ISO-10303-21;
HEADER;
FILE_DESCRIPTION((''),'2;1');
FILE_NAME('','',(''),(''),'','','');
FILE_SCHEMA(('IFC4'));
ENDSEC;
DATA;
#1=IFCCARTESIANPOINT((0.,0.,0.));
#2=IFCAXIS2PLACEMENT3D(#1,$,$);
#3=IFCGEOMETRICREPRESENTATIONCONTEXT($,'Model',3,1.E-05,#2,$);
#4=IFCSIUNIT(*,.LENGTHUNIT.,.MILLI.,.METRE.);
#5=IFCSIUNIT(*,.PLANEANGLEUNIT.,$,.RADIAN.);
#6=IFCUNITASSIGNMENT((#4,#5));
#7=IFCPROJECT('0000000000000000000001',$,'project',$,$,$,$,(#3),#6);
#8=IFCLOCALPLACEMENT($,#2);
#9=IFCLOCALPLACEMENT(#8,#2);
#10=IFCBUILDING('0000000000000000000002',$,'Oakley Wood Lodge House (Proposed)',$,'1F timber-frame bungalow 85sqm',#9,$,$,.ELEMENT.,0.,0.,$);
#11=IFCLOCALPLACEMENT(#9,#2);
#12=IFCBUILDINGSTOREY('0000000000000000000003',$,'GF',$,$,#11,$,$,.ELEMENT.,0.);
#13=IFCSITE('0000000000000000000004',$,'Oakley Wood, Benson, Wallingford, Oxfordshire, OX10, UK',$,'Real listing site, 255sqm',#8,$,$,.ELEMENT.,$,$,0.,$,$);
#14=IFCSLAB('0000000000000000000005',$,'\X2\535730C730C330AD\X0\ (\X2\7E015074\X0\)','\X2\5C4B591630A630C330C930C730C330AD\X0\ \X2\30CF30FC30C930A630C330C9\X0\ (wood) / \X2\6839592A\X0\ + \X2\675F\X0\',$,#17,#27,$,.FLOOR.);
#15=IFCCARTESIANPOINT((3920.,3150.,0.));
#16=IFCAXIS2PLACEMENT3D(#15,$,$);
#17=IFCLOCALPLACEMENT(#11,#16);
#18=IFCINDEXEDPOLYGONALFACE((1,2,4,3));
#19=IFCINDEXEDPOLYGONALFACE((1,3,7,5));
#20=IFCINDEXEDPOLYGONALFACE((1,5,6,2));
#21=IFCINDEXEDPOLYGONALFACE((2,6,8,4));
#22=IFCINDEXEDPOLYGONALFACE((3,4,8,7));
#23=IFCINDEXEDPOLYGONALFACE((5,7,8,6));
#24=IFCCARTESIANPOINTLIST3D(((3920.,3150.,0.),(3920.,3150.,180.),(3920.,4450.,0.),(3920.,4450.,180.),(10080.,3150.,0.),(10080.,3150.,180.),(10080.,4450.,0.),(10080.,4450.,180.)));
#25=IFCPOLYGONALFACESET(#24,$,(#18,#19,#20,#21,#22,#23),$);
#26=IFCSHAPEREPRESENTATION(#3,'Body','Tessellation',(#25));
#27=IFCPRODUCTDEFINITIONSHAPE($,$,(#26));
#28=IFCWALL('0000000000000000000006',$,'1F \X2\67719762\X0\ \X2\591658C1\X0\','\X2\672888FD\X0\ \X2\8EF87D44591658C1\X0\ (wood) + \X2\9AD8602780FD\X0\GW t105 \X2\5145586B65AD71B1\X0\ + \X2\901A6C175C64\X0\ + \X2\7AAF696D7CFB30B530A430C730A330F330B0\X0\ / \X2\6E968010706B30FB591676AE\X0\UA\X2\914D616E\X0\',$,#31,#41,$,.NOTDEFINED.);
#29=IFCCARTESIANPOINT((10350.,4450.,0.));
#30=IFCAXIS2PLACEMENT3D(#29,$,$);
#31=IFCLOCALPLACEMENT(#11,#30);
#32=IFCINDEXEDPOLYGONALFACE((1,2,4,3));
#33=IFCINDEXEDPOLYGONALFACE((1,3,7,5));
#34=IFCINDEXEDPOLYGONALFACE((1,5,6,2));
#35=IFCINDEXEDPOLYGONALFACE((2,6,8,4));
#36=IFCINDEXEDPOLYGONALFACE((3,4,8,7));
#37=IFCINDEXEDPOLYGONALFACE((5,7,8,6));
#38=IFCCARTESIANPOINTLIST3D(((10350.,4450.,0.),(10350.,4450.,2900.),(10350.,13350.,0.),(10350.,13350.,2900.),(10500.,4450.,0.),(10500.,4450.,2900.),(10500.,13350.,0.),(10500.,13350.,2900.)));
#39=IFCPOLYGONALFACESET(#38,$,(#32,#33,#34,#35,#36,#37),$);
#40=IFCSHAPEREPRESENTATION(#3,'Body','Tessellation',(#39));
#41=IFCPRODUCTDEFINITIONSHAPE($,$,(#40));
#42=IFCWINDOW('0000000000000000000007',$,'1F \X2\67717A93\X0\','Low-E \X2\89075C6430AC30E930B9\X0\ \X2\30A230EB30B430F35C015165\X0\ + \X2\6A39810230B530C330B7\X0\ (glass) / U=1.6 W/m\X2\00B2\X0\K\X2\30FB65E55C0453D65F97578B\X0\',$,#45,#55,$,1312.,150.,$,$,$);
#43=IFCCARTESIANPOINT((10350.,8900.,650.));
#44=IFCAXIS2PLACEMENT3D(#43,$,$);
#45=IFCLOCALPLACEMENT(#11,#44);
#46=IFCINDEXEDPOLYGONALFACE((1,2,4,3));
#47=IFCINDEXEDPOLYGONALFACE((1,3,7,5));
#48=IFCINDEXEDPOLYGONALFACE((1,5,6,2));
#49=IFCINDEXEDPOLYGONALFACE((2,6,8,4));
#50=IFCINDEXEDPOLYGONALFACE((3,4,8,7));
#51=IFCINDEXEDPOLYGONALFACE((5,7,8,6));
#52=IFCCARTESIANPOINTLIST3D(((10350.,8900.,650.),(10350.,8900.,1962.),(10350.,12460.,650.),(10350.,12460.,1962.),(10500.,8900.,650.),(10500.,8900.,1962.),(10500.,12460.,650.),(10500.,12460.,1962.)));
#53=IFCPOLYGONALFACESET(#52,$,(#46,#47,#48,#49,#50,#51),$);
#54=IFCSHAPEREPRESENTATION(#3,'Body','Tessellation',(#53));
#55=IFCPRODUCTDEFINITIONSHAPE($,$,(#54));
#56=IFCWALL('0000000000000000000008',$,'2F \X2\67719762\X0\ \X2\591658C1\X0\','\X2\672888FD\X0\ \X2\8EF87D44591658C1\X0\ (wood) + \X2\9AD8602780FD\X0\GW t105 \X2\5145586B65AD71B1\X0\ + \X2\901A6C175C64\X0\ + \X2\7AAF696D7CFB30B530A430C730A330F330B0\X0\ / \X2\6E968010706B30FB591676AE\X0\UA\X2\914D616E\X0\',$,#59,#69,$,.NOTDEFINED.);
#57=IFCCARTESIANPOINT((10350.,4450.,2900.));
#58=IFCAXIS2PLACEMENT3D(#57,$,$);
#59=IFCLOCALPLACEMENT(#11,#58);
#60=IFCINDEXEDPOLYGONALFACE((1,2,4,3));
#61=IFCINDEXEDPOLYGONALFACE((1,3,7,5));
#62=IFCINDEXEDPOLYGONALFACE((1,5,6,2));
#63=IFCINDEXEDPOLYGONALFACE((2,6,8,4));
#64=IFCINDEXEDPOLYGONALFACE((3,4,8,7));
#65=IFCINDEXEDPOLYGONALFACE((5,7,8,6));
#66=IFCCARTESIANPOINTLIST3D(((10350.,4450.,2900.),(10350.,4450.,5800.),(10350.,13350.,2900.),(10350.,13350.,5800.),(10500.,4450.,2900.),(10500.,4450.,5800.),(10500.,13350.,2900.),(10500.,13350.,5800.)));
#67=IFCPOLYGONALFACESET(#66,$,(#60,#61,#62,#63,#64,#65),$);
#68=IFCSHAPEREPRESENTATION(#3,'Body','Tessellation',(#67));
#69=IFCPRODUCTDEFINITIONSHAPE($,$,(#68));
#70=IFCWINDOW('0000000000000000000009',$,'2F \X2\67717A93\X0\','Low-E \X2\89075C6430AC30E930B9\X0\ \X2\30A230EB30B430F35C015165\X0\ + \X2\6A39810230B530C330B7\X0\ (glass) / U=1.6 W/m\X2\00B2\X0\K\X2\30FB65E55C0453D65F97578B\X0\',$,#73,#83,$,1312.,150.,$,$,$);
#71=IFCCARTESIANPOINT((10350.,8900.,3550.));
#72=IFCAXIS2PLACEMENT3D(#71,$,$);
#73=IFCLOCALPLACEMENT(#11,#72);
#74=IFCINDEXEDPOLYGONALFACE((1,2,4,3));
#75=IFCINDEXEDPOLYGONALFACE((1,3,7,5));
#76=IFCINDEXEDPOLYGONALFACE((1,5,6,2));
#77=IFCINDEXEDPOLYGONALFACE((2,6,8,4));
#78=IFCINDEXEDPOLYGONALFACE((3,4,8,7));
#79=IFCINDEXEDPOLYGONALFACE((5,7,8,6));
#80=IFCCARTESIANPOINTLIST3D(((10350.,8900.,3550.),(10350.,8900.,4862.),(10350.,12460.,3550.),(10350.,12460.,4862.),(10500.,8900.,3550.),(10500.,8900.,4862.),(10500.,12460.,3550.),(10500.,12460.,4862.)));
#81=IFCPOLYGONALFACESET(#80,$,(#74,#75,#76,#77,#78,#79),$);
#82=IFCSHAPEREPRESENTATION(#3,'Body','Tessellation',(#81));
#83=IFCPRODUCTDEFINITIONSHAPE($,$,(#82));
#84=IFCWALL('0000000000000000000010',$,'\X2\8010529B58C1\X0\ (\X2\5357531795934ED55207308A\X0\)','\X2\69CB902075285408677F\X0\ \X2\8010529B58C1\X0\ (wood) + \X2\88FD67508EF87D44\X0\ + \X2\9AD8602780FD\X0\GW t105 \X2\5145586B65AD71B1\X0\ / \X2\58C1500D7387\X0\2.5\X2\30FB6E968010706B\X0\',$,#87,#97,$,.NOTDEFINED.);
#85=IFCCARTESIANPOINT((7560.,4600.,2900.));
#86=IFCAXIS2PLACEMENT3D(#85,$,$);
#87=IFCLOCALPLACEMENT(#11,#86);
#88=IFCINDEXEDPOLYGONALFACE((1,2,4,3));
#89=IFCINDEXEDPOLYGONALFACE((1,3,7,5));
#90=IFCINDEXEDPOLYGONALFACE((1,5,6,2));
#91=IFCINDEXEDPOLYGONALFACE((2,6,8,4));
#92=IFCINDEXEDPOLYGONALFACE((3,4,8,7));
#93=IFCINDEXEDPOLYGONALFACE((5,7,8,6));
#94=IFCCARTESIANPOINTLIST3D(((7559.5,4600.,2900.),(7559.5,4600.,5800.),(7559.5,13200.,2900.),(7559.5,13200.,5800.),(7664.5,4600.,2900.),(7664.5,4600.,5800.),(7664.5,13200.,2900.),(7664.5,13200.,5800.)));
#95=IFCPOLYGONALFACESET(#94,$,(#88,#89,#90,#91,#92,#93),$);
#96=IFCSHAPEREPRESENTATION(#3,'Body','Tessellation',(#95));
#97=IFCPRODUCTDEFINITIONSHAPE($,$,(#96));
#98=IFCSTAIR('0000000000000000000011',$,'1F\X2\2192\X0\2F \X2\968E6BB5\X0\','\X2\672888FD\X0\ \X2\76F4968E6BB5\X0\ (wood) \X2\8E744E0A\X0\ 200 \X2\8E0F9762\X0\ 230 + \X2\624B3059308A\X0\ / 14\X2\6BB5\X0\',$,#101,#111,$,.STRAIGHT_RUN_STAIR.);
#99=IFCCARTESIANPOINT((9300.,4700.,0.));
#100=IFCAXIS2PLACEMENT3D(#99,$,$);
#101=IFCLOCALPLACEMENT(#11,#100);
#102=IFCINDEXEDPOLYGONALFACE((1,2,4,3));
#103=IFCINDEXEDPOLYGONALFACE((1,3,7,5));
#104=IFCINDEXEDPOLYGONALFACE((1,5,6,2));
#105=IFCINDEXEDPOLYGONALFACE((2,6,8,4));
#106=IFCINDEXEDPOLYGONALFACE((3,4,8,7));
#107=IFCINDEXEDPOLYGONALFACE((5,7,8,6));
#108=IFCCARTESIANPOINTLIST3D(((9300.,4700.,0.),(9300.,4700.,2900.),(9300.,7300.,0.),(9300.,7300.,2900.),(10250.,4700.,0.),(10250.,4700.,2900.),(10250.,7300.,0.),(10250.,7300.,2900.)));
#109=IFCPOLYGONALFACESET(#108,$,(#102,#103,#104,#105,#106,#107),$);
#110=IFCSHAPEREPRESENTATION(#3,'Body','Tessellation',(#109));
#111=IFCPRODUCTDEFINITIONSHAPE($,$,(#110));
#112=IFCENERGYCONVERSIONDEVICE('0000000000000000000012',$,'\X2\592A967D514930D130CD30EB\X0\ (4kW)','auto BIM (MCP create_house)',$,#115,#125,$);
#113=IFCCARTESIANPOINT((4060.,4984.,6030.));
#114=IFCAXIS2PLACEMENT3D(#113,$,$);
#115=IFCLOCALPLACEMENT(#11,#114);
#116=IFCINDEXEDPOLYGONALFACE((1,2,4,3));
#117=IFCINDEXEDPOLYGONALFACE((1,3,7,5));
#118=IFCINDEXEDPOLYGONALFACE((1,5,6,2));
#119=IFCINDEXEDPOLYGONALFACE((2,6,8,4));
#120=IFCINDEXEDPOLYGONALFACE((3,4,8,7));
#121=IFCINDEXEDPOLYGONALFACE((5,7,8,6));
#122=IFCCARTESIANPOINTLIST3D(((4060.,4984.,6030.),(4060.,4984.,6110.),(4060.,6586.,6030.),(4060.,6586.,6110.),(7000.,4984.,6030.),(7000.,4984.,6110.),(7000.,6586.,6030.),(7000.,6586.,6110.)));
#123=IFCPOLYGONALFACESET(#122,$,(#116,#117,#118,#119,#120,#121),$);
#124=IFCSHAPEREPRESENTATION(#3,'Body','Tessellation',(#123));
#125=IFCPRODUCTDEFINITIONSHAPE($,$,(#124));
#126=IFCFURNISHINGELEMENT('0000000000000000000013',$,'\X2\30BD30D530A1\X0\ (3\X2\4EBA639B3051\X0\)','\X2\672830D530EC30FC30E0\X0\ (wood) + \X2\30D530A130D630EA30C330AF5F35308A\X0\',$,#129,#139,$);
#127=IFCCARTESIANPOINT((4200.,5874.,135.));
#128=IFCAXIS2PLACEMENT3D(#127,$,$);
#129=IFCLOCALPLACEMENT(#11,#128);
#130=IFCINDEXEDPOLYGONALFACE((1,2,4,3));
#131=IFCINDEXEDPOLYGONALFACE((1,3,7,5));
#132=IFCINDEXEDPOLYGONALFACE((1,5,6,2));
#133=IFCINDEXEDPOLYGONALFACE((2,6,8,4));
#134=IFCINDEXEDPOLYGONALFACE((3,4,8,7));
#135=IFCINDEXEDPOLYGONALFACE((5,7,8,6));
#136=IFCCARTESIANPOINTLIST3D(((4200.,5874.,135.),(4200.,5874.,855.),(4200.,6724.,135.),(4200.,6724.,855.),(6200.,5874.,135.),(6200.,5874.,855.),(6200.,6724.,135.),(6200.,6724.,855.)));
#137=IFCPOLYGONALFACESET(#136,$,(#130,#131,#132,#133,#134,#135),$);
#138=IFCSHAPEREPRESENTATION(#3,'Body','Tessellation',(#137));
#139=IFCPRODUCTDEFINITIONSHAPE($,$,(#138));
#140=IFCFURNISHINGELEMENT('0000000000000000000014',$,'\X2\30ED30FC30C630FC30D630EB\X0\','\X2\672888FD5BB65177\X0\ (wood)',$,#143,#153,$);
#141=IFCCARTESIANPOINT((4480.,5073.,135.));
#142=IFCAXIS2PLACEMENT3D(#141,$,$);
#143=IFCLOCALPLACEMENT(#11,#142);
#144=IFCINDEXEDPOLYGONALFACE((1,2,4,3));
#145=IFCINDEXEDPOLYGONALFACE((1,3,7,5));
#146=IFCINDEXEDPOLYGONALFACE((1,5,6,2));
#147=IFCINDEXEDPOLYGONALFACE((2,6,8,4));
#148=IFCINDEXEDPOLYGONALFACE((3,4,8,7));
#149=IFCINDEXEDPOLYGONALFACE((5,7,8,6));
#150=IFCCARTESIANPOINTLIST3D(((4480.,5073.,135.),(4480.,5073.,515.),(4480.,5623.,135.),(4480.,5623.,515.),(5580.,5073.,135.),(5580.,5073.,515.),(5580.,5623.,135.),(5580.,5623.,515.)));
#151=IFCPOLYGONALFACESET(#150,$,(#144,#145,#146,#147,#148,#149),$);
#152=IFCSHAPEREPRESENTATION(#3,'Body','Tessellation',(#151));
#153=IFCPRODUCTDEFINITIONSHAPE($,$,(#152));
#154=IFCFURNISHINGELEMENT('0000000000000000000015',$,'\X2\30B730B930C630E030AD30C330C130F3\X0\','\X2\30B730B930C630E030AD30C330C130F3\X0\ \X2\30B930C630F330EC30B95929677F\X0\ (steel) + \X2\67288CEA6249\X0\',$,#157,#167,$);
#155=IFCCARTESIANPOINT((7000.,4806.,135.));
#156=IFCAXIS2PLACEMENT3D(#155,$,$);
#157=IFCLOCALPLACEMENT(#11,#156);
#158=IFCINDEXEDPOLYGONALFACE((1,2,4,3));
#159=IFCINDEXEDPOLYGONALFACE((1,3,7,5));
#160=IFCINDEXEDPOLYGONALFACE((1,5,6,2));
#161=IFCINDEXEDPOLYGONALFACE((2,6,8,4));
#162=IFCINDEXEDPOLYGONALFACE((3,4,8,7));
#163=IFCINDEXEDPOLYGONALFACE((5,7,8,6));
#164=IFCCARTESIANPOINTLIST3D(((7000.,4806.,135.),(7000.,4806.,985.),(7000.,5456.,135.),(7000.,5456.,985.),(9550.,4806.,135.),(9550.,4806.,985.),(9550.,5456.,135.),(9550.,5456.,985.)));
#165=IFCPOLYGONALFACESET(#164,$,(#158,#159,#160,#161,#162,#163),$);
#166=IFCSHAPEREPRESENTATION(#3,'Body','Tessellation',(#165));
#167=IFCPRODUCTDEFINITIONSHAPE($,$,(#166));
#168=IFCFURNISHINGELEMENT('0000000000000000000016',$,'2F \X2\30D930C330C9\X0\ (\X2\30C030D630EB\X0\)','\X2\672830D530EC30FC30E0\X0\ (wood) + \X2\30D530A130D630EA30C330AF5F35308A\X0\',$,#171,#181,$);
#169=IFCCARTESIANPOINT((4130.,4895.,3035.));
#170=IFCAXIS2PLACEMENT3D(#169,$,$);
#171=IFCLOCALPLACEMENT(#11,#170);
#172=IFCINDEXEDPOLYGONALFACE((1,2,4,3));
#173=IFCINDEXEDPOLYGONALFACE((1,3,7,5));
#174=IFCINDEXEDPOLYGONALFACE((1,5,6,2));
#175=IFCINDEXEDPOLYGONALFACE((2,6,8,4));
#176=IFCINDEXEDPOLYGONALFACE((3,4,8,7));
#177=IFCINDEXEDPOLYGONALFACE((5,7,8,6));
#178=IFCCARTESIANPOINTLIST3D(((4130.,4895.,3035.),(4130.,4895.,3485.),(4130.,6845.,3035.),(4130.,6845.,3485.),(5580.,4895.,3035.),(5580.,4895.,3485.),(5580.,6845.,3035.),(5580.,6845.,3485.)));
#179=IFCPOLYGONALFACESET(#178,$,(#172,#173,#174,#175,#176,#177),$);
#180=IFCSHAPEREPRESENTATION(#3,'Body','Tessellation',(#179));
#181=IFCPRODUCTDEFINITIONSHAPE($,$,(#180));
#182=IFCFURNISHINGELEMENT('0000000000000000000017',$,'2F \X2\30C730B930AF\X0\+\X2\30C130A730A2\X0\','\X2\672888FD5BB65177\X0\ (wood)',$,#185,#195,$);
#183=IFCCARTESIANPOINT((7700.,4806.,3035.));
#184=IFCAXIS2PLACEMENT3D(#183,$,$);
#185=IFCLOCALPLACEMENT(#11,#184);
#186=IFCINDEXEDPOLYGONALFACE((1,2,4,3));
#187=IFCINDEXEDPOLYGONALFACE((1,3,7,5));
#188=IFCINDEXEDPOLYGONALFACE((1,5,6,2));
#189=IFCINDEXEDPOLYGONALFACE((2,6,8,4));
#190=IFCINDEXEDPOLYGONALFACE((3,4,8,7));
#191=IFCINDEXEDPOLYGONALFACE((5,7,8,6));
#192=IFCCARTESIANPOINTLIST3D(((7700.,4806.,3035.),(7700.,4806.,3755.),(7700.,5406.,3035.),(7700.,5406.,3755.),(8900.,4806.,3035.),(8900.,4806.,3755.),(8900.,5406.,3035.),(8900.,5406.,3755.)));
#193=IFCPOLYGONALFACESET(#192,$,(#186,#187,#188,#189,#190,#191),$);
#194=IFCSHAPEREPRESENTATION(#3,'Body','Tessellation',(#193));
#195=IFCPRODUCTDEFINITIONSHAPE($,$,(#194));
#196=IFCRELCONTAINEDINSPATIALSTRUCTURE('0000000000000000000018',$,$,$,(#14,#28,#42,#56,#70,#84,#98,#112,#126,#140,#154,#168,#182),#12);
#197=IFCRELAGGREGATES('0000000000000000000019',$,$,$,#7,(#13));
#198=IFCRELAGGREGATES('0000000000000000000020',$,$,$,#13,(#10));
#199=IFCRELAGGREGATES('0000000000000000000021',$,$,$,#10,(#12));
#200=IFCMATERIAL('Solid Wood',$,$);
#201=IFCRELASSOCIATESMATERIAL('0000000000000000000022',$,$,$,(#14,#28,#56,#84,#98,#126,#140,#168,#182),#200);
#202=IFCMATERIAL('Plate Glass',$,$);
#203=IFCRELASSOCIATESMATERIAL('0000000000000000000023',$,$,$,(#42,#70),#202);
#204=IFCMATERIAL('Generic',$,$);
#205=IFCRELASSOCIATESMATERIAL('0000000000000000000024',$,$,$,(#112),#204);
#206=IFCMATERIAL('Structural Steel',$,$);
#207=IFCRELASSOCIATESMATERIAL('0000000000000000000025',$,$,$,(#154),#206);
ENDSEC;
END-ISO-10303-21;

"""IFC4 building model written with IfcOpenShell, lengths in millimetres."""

from ifc_helpers import new_model, si_unit, frame, frame_2d, origin, place, context, project, spatial, rectangle, extrude, material, element, fill, save


model = new_model("IFC4")

# Units and contexts
model_context = context("Model", 3, precision=1e-05, world=origin())
ifc_project = project(units=[si_unit("LENGTHUNIT", "METRE", prefix="MILLI"), si_unit("PLANEANGLEUNIT", "RADIAN")], contexts=[model_context])

# Site, building, storey
site_placement = place(None, origin())
site = spatial("IfcSite", under=ifc_project, at=site_placement, Name="Oakley Wood, Benson, Wallingford, Oxfordshire, OX10, UK", ObjectType="Real listing site, 255sqm", CompositionType="ELEMENT", RefElevation=0.0)
building_placement = place(site_placement, origin())
building = spatial("IfcBuilding", under=site, at=building_placement, Name="Oakley Wood Lodge House (Proposed)", ObjectType="1F timber-frame bungalow 85sqm", CompositionType="ELEMENT", ElevationOfRefHeight=0.0, ElevationOfTerrain=0.0)
storey_placement = place(building_placement, origin())
storey = spatial("IfcBuildingStorey", under=building, at=storey_placement, Name="GF", CompositionType="ELEMENT", Elevation=0.0)

# Slab
ifc_material_1 = material(Name="Solid Wood")
slab_placement = place(storey_placement, frame((3920.0, 3150.0, 0.0)))
element("IfcSlab", 1, at=slab_placement, inside=storey, material=ifc_material_1, Name="南デッキ (縁側)", Description="屋外ウッドデッキ ハードウッド (wood) / 根太 + 束", PredefinedType="FLOOR", context=model_context, shape_type="SweptSolid", body=[
    extrude(rectangle(XDim=6160.0, YDim=1300.0, at=frame_2d((3080.0, 650.0))), frame((3920.0, 3150.0, 0.0)), (0.0, 0.0, 1.0), 180.0),
])

# Wall, opening, window
wall_1_placement = place(storey_placement, frame((10350.0, 4450.0, 0.0)))
wall_1 = element("IfcWall", 2, at=wall_1_placement, inside=storey, material=ifc_material_1, Name="1F 東面 外壁", Description="木製 軸組外壁 (wood) + 高性能GW t105 充填断熱 + 通気層 + 窯業系サイディング / 準耐火・外皮UA配慮", PredefinedType="NOTDEFINED", context=model_context, shape_type="SweptSolid", body=[
    extrude(rectangle(XDim=150.0, YDim=8900.0, at=frame_2d((75.0, 4450.0))), frame((10350.0, 4450.0, 0.0)), (0.0, 0.0, 1.0), 2900.0),
])
opening_1_placement = place(storey_placement, frame((10350.0, 8900.0, 650.0)))
opening_1 = element("IfcOpeningElement", 3, at=opening_1_placement, cuts=wall_1, PredefinedType="NOTDEFINED", context=model_context, shape_type="SweptSolid", body=[
    extrude(rectangle(XDim=150.0, YDim=3560.0, at=frame_2d((75.0, 1780.0))), frame((10350.0, 8900.0, 650.0)), (0.0, 0.0, 1.0), 1312.0),
])
ifc_material_2 = material(Name="Plate Glass")
window_1_placement = place(storey_placement, frame((10350.0, 8900.0, 650.0)))
window_1 = element("IfcWindow", 4, at=window_1_placement, inside=storey, material=ifc_material_2, Name="1F 東窓", Description="Low-E 複層ガラス アルゴン封入 + 樹脂サッシ (glass) / U=1.6 W/m²K・日射取得型", OverallHeight=1312.0, OverallWidth=150.0, context=model_context, shape_type="SweptSolid", body=[
    extrude(rectangle(XDim=150.0, YDim=3560.0, at=frame_2d((75.0, 1780.0))), frame((10350.0, 8900.0, 650.0)), (0.0, 0.0, 1.0), 1312.0),
])
fill(opening_1, window_1)

# Wall, opening, window
wall_2_placement = place(storey_placement, frame((10350.0, 4450.0, 2900.0)))
wall_2 = element("IfcWall", 5, at=wall_2_placement, inside=storey, material=ifc_material_1, Name="2F 東面 外壁", Description="木製 軸組外壁 (wood) + 高性能GW t105 充填断熱 + 通気層 + 窯業系サイディング / 準耐火・外皮UA配慮", PredefinedType="NOTDEFINED", context=model_context, shape_type="SweptSolid", body=[
    extrude(rectangle(XDim=150.0, YDim=8900.0, at=frame_2d((75.0, 4450.0))), frame((10350.0, 4450.0, 2900.0)), (0.0, 0.0, 1.0), 2900.0),
])
opening_2_placement = place(storey_placement, frame((10350.0, 8900.0, 3550.0)))
opening_2 = element("IfcOpeningElement", 6, at=opening_2_placement, cuts=wall_2, PredefinedType="NOTDEFINED", context=model_context, shape_type="SweptSolid", body=[
    extrude(rectangle(XDim=150.0, YDim=3560.0, at=frame_2d((75.0, 1780.0))), frame((10350.0, 8900.0, 3550.0)), (0.0, 0.0, 1.0), 1312.0),
])
window_2_placement = place(storey_placement, frame((10350.0, 8900.0, 3550.0)))
window_2 = element("IfcWindow", 7, at=window_2_placement, inside=storey, material=ifc_material_2, Name="2F 東窓", Description="Low-E 複層ガラス アルゴン封入 + 樹脂サッシ (glass) / U=1.6 W/m²K・日射取得型", OverallHeight=1312.0, OverallWidth=150.0, context=model_context, shape_type="SweptSolid", body=[
    extrude(rectangle(XDim=150.0, YDim=3560.0, at=frame_2d((75.0, 1780.0))), frame((10350.0, 8900.0, 3550.0)), (0.0, 0.0, 1.0), 1312.0),
])
fill(opening_2, window_2)

# Wall
wall_3_placement = place(storey_placement, frame((7560.0, 4600.0, 2900.0)))
element("IfcWall", 8, at=wall_3_placement, inside=storey, material=ifc_material_1, Name="耐力壁 (南北間仕切り)", Description="構造用合板 耐力壁 (wood) + 製材軸組 + 高性能GW t105 充填断熱 / 壁倍率2.5・準耐火", PredefinedType="NOTDEFINED", context=model_context, shape_type="SweptSolid", body=[
    extrude(rectangle(XDim=105.0, YDim=8600.0, at=frame_2d((52.0, 4300.0))), frame((7560.0, 4600.0, 2900.0)), (0.0, 0.0, 1.0), 2900.0),
])

# Stair
stair_placement = place(storey_placement, frame((9300.0, 4700.0, 0.0)))
element("IfcStair", 9, at=stair_placement, inside=storey, material=ifc_material_1, Name="1F→2F 階段", Description="木製 直階段 (wood) 蹴上 200 踏面 230 + 手すり / 14段", PredefinedType="STRAIGHT_RUN_STAIR", context=model_context, shape_type="SweptSolid", body=[
    extrude(rectangle(XDim=950.0, YDim=2600.0, at=frame_2d((475.0, 1300.0))), frame((9300.0, 4700.0, 0.0)), (0.0, 0.0, 1.0), 2900.0),
])

# Energy conversion device
ifc_material_3 = material(Name="Generic")
energy_conversion_device_placement = place(storey_placement, frame((4060.0, 4984.0, 6030.0)))
element("IfcEnergyConversionDevice", 10, at=energy_conversion_device_placement, inside=storey, material=ifc_material_3, Name="太陽光パネル (4kW)", Description="auto BIM (MCP create_house)", context=model_context, shape_type="SweptSolid", body=[
    extrude(rectangle(XDim=2940.0, YDim=1602.0, at=frame_2d((1470.0, 801.0))), frame((4060.0, 4984.0, 6030.0)), (0.0, 0.0, 1.0), 80.0),
])

# Furnishing elements
furnishing_1_placement = place(storey_placement, frame((4200.0, 5874.0, 135.0)))
element("IfcFurnishingElement", 11, at=furnishing_1_placement, inside=storey, material=ifc_material_1, Name="ソファ (3人掛け)", Description="木フレーム (wood) + ファブリック張り", context=model_context, shape_type="SweptSolid", body=[
    extrude(rectangle(XDim=2000.0, YDim=850.0, at=frame_2d((1000.0, 425.0))), frame((4200.0, 5874.0, 135.0)), (0.0, 0.0, 1.0), 720.0),
])
furnishing_2_placement = place(storey_placement, frame((4480.0, 5073.0, 135.0)))
element("IfcFurnishingElement", 12, at=furnishing_2_placement, inside=storey, material=ifc_material_1, Name="ローテーブル", Description="木製家具 (wood)", context=model_context, shape_type="SweptSolid", body=[
    extrude(rectangle(XDim=1100.0, YDim=550.0, at=frame_2d((550.0, 275.0))), frame((4480.0, 5073.0, 135.0)), (0.0, 0.0, 1.0), 380.0),
])
ifc_material_4 = material(Name="Structural Steel")
furnishing_3_placement = place(storey_placement, frame((7000.0, 4806.0, 135.0)))
element("IfcFurnishingElement", 13, at=furnishing_3_placement, inside=storey, material=ifc_material_4, Name="システムキッチン", Description="システムキッチン ステンレス天板 (steel) + 木質扉", context=model_context, shape_type="SweptSolid", body=[
    extrude(rectangle(XDim=2550.0, YDim=650.0, at=frame_2d((1275.0, 325.0))), frame((7000.0, 4806.0, 135.0)), (0.0, 0.0, 1.0), 850.0),
])
furnishing_4_placement = place(storey_placement, frame((4130.0, 4895.0, 3035.0)))
element("IfcFurnishingElement", 14, at=furnishing_4_placement, inside=storey, material=ifc_material_1, Name="2F ベッド (ダブル)", Description="木フレーム (wood) + ファブリック張り", context=model_context, shape_type="SweptSolid", body=[
    extrude(rectangle(XDim=1450.0, YDim=1950.0, at=frame_2d((725.0, 975.0))), frame((4130.0, 4895.0, 3035.0)), (0.0, 0.0, 1.0), 450.0),
])
furnishing_5_placement = place(storey_placement, frame((7700.0, 4806.0, 3035.0)))
element("IfcFurnishingElement", 15, at=furnishing_5_placement, inside=storey, material=ifc_material_1, Name="2F デスク+チェア", Description="木製家具 (wood)", context=model_context, shape_type="SweptSolid", body=[
    extrude(rectangle(XDim=1200.0, YDim=600.0, at=frame_2d((600.0, 300.0))), frame((7700.0, 4806.0, 3035.0)), (0.0, 0.0, 1.0), 720.0),
])

save(model, "model.ifc")
